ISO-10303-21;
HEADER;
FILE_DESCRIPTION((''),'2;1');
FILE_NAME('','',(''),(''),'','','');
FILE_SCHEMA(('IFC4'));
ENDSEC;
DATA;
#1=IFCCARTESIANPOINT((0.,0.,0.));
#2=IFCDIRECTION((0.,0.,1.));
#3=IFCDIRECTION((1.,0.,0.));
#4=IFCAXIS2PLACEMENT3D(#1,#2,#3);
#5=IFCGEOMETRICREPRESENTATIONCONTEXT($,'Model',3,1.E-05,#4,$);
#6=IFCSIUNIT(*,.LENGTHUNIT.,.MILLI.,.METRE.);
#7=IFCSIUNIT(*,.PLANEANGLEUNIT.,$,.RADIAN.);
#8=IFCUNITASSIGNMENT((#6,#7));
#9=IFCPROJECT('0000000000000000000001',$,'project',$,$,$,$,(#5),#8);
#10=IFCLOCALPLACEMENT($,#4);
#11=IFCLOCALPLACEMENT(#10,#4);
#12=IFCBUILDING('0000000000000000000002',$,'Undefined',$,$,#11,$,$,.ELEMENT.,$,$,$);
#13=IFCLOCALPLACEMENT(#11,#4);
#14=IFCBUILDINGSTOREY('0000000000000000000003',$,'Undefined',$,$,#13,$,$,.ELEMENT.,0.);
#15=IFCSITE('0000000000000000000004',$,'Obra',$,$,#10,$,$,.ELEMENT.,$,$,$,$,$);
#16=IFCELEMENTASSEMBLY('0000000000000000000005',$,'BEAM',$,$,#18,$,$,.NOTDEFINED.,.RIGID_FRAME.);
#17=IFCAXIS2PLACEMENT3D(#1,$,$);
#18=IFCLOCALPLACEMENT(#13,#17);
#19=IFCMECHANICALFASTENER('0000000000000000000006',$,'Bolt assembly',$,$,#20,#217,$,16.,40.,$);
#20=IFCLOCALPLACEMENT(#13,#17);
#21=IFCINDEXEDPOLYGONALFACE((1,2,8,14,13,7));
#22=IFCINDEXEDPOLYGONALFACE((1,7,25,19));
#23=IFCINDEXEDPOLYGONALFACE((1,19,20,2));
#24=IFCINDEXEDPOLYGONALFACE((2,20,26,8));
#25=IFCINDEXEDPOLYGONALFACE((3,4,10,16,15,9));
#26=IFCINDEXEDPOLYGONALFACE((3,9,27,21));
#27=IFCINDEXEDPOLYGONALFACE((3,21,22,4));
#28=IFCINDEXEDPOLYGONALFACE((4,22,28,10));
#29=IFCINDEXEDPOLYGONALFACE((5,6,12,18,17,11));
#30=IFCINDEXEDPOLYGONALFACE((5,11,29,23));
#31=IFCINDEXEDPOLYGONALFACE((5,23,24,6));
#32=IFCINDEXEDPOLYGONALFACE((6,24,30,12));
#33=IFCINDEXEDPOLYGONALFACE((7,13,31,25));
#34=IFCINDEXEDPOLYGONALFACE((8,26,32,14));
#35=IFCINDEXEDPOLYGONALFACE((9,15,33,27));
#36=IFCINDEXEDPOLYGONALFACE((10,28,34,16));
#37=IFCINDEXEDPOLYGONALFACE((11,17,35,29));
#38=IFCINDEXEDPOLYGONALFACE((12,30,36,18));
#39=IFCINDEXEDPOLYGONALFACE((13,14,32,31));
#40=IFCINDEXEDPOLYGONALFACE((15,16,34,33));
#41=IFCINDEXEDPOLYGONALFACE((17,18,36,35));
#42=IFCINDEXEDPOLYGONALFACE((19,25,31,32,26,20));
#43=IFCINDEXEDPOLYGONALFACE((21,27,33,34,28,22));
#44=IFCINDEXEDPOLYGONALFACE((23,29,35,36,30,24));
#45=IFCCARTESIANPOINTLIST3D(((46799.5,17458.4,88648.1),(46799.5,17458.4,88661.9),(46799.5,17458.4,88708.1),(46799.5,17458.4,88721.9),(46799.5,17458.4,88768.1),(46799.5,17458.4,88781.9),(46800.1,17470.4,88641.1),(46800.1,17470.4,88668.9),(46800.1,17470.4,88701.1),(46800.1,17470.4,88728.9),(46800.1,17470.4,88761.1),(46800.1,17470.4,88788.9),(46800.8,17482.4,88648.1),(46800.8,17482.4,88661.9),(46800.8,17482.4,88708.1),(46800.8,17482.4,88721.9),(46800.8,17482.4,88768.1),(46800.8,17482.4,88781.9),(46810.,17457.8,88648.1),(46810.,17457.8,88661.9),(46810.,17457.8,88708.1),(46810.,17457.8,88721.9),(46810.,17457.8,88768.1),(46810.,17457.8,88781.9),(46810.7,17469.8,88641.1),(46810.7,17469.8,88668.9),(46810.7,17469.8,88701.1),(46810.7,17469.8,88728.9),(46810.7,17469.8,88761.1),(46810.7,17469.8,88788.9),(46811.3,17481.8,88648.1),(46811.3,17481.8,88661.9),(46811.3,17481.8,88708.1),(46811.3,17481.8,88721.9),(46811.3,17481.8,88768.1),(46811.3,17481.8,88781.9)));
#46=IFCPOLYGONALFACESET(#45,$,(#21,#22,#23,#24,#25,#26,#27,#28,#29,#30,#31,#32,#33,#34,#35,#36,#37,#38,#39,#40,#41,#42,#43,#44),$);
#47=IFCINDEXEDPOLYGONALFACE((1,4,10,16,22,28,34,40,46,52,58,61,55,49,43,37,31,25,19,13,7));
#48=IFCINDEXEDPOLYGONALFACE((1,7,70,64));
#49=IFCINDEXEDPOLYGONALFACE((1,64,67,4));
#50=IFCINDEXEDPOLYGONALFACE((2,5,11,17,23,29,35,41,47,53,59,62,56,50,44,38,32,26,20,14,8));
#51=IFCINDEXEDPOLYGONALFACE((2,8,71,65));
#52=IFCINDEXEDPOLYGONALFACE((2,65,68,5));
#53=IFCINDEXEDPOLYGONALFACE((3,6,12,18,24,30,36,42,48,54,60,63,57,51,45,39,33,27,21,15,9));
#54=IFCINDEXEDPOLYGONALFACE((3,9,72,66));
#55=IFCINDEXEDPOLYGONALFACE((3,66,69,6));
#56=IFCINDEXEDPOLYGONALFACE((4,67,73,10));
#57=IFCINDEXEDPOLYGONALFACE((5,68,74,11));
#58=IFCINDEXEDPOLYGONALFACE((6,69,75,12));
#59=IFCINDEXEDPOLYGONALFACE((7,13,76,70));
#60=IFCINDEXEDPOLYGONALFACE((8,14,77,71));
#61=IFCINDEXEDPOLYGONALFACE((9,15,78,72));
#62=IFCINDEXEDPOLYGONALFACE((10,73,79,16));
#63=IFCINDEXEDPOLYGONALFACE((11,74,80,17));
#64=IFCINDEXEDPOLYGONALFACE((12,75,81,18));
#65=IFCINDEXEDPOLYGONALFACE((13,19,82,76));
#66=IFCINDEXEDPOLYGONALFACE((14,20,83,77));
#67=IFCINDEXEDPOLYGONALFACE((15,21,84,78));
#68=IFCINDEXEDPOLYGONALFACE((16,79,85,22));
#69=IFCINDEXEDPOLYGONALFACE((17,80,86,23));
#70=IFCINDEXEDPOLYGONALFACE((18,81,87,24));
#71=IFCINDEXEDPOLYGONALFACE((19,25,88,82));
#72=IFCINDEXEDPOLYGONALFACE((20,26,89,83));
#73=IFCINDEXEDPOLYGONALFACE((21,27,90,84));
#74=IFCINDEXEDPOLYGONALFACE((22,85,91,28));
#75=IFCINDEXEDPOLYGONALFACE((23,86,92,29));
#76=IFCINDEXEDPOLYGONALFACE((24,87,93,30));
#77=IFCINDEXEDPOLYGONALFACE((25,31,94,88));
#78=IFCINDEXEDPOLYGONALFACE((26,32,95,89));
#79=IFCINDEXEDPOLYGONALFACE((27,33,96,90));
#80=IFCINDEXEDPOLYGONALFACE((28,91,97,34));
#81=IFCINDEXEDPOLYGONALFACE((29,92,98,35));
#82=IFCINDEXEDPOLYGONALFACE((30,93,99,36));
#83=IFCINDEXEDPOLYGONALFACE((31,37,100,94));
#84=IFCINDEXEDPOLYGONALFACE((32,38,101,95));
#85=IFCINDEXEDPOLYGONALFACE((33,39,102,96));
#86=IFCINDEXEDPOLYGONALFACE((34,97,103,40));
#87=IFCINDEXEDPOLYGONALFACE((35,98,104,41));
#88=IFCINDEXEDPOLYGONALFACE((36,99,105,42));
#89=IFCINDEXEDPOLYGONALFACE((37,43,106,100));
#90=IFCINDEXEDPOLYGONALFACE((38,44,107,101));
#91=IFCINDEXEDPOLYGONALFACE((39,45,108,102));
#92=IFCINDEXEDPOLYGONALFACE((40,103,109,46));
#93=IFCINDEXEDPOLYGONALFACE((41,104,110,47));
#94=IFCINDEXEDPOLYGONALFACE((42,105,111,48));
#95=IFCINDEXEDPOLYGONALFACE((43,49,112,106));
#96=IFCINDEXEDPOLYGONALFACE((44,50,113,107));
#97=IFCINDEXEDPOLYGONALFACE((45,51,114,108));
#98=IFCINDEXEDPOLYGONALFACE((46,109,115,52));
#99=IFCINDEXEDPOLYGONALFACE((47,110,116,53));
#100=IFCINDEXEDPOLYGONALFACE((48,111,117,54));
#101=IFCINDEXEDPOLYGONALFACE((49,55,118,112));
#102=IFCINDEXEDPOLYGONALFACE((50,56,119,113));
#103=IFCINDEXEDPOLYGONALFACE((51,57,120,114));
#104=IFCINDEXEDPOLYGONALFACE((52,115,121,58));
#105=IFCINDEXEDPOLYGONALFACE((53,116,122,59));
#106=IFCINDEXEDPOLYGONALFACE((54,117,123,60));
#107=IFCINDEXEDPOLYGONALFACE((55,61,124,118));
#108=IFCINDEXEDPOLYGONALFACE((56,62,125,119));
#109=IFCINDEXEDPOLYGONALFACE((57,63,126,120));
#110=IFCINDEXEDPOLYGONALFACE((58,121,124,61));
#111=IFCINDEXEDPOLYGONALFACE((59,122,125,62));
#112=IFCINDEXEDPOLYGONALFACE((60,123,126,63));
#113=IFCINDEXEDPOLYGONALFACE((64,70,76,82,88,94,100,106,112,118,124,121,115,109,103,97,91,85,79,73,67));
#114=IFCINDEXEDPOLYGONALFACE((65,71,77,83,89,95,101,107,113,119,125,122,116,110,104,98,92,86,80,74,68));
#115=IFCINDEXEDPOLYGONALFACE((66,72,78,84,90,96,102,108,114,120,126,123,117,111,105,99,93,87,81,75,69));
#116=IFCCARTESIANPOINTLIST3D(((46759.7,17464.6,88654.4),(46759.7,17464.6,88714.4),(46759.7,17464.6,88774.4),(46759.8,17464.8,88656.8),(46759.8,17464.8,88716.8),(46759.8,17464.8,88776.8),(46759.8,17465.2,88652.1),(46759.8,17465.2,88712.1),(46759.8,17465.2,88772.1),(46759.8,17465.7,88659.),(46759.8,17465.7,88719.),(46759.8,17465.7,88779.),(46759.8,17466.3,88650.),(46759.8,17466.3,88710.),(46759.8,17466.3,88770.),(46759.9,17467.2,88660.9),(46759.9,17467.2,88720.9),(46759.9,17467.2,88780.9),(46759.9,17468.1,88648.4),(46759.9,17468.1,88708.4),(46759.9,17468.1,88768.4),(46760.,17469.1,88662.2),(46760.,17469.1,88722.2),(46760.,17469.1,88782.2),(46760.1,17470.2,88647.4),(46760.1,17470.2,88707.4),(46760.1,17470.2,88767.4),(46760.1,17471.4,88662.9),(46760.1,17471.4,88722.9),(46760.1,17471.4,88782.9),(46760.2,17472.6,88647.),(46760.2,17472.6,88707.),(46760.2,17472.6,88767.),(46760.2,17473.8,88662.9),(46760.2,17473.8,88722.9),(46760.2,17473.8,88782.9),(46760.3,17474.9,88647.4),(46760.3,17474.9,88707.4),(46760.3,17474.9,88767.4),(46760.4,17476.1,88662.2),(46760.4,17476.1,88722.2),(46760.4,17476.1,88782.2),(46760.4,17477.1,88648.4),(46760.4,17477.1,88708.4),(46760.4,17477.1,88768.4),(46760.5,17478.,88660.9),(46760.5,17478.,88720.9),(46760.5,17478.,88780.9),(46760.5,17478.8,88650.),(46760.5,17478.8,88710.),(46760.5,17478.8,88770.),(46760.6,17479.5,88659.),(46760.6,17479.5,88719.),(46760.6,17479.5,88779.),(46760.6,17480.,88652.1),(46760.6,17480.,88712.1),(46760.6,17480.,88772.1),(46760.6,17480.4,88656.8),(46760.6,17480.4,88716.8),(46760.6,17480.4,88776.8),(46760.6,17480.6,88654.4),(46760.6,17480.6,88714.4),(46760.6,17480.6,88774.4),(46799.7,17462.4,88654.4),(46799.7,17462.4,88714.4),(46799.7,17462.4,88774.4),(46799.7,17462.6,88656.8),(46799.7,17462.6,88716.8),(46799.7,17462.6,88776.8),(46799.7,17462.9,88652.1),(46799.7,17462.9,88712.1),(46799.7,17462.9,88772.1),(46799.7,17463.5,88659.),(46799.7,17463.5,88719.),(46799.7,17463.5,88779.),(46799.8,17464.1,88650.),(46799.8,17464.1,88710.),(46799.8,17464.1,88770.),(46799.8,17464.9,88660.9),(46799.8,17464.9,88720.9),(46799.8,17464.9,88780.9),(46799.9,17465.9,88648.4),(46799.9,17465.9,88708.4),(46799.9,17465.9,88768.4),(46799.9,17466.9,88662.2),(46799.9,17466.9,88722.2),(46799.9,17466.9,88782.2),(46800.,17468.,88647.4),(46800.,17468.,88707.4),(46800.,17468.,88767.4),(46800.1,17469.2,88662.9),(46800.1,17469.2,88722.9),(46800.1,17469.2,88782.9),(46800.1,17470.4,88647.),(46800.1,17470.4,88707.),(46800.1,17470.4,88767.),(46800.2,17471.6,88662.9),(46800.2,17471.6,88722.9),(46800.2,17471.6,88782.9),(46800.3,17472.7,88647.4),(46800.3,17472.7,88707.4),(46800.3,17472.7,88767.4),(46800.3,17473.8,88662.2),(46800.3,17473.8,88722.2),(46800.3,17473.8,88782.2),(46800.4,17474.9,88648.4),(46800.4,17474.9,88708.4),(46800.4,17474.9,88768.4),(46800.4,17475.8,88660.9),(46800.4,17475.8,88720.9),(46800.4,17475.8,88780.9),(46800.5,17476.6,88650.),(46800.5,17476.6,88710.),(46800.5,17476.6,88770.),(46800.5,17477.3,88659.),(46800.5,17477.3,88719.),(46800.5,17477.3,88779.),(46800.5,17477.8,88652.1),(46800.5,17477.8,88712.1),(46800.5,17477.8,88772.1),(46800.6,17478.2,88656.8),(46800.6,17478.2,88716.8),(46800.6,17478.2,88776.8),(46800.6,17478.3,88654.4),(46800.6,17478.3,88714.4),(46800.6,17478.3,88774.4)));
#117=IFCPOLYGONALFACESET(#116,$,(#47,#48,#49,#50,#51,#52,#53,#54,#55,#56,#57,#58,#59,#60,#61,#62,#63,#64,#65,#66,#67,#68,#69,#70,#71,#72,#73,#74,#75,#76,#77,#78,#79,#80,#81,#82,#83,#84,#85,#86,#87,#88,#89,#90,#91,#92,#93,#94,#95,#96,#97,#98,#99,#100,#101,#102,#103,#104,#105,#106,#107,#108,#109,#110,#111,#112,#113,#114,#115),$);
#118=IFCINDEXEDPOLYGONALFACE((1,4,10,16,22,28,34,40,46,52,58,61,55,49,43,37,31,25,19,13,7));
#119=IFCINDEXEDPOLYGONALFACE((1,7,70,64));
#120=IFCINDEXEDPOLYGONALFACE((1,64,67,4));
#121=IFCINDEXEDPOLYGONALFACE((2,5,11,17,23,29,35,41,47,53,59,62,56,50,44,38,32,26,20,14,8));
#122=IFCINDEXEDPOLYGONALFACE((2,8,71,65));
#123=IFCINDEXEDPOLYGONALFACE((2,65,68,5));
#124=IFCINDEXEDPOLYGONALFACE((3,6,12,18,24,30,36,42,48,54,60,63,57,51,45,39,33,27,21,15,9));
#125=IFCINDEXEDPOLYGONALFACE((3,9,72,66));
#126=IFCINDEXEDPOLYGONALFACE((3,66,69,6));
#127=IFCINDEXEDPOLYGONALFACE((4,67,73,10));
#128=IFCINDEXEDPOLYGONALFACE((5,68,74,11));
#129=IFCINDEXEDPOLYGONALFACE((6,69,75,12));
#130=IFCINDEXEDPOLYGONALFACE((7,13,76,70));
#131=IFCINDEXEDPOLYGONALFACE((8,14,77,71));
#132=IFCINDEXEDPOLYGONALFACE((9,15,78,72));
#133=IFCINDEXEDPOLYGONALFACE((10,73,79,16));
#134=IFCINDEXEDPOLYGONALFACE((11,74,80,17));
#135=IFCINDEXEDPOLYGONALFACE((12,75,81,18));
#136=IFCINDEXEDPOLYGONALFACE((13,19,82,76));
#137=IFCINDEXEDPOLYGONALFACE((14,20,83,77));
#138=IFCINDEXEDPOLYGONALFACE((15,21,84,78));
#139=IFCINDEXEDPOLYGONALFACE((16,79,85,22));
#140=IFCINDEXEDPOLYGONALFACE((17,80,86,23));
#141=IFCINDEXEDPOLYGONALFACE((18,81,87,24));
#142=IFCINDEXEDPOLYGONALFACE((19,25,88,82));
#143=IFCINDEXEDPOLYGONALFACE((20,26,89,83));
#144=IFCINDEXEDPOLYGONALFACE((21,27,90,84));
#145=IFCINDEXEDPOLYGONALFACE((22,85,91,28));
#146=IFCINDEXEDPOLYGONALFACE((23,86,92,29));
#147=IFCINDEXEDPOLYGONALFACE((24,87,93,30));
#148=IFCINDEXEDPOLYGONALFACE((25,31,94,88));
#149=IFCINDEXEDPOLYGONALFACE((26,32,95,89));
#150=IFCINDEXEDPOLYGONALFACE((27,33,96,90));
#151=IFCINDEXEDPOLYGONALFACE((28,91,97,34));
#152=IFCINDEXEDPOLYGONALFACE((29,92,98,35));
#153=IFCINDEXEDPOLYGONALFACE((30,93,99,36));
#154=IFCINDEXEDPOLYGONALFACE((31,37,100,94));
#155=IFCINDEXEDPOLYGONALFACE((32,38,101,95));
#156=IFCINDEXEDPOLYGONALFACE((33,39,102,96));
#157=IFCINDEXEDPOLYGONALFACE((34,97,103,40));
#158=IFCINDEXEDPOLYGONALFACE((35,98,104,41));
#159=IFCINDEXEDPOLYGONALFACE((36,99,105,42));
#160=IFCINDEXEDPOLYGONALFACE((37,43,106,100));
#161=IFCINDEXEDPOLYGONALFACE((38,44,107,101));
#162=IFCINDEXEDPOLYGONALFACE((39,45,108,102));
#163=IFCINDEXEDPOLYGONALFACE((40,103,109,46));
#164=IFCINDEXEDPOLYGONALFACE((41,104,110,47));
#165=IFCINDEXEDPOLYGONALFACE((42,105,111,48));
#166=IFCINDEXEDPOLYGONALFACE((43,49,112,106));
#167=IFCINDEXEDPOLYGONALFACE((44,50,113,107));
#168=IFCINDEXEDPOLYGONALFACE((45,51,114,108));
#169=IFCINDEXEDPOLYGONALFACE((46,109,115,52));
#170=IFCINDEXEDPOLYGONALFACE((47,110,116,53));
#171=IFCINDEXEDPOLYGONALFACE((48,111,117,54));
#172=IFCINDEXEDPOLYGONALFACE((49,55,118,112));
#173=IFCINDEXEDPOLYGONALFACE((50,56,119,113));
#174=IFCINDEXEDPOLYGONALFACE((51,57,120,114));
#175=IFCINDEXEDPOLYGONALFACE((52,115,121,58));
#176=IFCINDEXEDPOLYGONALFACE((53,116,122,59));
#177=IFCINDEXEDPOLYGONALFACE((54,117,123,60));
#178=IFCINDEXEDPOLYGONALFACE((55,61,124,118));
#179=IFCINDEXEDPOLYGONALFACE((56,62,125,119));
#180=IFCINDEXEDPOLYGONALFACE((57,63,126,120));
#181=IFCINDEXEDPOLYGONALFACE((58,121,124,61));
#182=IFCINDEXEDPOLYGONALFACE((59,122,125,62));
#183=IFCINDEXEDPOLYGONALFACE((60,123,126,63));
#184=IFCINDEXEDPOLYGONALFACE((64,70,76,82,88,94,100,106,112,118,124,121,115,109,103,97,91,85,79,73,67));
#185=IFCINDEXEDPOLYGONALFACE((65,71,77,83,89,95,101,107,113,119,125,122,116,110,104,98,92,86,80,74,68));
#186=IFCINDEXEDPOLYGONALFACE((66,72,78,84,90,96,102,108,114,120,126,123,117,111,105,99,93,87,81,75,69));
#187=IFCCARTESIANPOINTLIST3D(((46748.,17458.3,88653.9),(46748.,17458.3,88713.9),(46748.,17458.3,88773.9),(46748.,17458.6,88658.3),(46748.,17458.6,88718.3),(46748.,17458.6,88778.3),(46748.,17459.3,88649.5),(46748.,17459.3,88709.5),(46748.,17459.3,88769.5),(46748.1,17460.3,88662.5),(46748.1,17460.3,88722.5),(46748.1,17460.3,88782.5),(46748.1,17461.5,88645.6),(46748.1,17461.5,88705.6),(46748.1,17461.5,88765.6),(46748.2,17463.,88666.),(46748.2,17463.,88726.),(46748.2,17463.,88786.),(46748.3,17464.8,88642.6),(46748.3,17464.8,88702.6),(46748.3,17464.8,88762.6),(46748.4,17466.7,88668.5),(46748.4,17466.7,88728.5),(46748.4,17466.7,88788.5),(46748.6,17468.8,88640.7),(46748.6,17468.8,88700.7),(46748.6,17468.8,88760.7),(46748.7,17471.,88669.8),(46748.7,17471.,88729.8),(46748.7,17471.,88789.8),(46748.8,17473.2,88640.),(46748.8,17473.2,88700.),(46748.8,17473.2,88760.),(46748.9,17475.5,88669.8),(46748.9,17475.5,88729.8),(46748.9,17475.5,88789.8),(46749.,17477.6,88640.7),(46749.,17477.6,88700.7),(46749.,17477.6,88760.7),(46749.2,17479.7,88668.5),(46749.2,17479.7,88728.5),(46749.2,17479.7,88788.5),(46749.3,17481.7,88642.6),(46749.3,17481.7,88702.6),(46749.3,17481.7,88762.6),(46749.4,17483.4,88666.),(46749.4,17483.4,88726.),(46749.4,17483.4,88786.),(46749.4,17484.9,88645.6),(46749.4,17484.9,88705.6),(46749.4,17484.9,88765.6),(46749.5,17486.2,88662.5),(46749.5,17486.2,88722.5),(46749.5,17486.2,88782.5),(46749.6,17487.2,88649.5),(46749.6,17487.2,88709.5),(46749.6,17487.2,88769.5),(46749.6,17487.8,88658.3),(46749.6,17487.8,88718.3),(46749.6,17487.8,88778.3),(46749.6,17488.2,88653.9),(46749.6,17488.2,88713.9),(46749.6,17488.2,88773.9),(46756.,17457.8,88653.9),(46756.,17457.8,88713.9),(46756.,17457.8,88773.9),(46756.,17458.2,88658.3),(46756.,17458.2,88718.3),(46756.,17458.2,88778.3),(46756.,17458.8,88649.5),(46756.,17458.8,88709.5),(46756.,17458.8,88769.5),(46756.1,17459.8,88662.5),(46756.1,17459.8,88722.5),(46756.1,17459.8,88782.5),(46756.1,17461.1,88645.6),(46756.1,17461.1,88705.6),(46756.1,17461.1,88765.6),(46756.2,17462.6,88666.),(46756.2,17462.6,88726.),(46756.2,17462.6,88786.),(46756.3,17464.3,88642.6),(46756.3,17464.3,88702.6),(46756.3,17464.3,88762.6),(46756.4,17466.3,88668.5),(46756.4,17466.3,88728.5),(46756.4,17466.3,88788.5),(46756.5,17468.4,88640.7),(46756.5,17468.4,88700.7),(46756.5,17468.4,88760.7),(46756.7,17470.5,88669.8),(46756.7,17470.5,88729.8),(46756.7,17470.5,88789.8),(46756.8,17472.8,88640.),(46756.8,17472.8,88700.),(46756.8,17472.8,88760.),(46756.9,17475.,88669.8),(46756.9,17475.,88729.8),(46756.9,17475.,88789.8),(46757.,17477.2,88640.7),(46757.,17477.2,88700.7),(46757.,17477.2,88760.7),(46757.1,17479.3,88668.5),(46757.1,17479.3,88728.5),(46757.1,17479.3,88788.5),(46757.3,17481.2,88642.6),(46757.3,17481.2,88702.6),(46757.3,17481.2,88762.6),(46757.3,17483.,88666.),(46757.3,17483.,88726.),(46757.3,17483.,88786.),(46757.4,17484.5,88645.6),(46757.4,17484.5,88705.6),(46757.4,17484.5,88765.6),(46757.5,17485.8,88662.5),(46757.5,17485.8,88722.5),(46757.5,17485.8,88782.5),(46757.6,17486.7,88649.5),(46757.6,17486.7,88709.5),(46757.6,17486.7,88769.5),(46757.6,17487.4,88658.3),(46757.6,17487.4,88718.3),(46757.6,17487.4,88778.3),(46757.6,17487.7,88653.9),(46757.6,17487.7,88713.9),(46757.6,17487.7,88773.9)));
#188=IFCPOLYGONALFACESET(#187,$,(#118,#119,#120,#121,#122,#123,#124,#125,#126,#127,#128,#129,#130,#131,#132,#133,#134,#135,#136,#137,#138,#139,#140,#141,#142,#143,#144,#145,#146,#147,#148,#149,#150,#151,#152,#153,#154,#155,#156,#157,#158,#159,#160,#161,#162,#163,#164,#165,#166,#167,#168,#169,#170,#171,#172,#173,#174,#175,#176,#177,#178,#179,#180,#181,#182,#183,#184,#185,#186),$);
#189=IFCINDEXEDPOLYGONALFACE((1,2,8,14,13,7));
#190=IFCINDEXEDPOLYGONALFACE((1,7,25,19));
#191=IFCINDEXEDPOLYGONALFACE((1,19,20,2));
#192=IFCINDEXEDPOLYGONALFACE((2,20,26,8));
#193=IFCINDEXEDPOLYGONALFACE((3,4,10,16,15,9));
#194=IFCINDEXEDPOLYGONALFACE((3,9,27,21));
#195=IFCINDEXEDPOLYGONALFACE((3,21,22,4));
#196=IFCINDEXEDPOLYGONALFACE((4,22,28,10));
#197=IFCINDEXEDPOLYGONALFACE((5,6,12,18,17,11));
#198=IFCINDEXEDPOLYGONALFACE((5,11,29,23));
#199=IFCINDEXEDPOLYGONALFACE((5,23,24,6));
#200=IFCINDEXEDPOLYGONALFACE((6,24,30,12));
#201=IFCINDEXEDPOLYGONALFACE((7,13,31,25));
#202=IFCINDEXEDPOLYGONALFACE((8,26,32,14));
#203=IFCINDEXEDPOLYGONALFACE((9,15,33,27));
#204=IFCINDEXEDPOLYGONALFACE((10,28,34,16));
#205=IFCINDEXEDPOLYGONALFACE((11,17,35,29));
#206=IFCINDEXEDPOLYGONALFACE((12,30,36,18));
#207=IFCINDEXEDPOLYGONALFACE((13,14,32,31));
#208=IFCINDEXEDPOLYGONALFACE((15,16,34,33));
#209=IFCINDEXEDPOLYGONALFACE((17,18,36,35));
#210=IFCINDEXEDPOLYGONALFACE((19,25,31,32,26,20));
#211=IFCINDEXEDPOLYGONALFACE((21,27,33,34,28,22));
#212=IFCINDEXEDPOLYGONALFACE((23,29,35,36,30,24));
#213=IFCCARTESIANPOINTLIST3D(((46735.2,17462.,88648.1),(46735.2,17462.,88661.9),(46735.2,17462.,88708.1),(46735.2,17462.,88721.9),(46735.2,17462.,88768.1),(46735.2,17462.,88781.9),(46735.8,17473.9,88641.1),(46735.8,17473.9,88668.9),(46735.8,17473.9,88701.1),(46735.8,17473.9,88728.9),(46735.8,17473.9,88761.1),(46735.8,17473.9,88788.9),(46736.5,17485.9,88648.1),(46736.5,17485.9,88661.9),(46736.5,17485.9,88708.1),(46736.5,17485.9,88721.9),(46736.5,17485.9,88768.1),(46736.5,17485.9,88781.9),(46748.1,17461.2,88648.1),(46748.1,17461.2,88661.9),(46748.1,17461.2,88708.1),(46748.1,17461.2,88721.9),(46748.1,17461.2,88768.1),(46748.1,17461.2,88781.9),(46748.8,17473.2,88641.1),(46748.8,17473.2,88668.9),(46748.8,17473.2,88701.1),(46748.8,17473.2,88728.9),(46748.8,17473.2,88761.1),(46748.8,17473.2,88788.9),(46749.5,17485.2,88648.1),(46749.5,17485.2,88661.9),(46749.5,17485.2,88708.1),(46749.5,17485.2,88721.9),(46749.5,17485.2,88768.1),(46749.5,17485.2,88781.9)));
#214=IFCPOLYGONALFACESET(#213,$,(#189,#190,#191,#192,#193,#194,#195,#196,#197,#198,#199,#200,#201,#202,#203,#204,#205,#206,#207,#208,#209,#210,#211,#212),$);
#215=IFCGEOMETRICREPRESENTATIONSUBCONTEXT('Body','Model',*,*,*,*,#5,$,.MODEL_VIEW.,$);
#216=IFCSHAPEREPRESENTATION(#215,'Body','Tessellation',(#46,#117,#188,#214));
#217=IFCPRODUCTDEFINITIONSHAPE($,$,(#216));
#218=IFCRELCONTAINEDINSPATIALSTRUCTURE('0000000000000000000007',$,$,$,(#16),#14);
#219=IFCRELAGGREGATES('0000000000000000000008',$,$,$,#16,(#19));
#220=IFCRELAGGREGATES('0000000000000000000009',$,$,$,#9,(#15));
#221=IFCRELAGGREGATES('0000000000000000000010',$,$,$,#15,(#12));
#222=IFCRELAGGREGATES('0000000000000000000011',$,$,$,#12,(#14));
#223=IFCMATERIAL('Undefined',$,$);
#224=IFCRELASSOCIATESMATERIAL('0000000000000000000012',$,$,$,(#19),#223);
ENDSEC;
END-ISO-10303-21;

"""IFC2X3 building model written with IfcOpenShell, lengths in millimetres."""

from ifc_helpers import new_model, si_unit, frame, origin_with_axes, origin_2d_with_axis, place, context, subcontext, project, spatial, polyline, circle, outline, extrude, source, transform, mapped, material, element, aggregate, save


model = new_model("IFC2X3")

# Units and contexts
model_context = context("Model", 3, precision=1e-05, world=origin_with_axes())
body_context = subcontext(model_context, "Body", "Model", "MODEL_VIEW")
ifc_project = project(units=[si_unit("LENGTHUNIT", "METRE", prefix="MILLI"), si_unit("PLANEANGLEUNIT", "RADIAN")], contexts=[model_context])

# Site, building, storey
site_placement = place(None, origin_with_axes())
site = spatial("IfcSite", under=ifc_project, at=site_placement, Name="Obra", CompositionType="ELEMENT")
building_placement = place(site_placement, origin_with_axes())
building = spatial("IfcBuilding", under=site, at=building_placement, Name="Undefined", CompositionType="ELEMENT")
storey_placement = place(building_placement, origin_with_axes())
storey = spatial("IfcBuildingStorey", under=building, at=storey_placement, Name="Undefined", CompositionType="ELEMENT", Elevation=0.0)

# Element assembly, mechanical fastener
ifc_material_1 = material(Name="Undefined")
shared_shape_1 = source(origin_with_axes(), body_context, "Body", "SweptSolid", [
    extrude(outline(polyline([(13.9, 0.0), (6.9, 12.0), (-6.9, 12.0), (-13.9, 0.0), (-6.9, -12.0), (6.9, -12.0), (13.9, 0.0)])), frame((0.0, -19.7, 0.0), z_axis=(0.0, 1.0, 0.0), x_axis=(1.0, 0.0, 0.0)), (0.0, 0.0, 1.0), 10.6),
    extrude(circle(Radius=8.0, at=origin_2d_with_axis()), frame((0.0, -9.1, 0.0), z_axis=(0.0, 1.0, 0.0), x_axis=(1.0, 0.0, 0.0)), (0.0, 0.0, 1.0), 40.0),
    extrude(circle(Radius=15.0, at=origin_2d_with_axis()), frame((0.0, 34.3, 0.0), z_axis=(0.0, 1.0, 0.0), x_axis=(1.0, 0.0, 0.0)), (0.0, 0.0, 1.0), 8.0),
    extrude(outline(polyline([(13.9, 0.0), (6.9, 12.0), (-6.9, 12.0), (-13.9, 0.0), (-6.9, -12.0), (6.9, -12.0), (13.9, 0.0)])), frame((0.0, 42.3, 0.0), z_axis=(0.0, 1.0, 0.0), x_axis=(1.0, 0.0, 0.0)), (0.0, 0.0, 1.0), 13.0),
])
assembly_1_placement = place(storey_placement, origin_with_axes())
assembly_1 = element("IfcElementAssembly", 1, at=assembly_1_placement, inside=storey, Name="BEAM", AssemblyPlace="NOTDEFINED", PredefinedType="RIGID_FRAME")
mechanical_fastener_1_placement = place(assembly_1_placement, frame((46788.3, 17421.0, 88835.0), z_axis=(0.055268, 0.998472, 0.0), x_axis=(0.0, 0.0, -1.0)))
mechanical_fastener_1 = element("IfcMechanicalFastener", 2, at=mechanical_fastener_1_placement, material=ifc_material_1, Name="Bolt assembly", NominalDiameter=16.0, NominalLength=40.0, context=body_context, shape_type="MappedRepresentation", body=[
    mapped(shared_shape_1, transform((60.0, 0.0, 50.0))),
    mapped(shared_shape_1, transform((120.0, 0.0, 50.0))),
    mapped(shared_shape_1, transform((180.0, 0.0, 50.0))),
])

aggregate(assembly_1, [mechanical_fastener_1])

save(model, "model.ifc")
